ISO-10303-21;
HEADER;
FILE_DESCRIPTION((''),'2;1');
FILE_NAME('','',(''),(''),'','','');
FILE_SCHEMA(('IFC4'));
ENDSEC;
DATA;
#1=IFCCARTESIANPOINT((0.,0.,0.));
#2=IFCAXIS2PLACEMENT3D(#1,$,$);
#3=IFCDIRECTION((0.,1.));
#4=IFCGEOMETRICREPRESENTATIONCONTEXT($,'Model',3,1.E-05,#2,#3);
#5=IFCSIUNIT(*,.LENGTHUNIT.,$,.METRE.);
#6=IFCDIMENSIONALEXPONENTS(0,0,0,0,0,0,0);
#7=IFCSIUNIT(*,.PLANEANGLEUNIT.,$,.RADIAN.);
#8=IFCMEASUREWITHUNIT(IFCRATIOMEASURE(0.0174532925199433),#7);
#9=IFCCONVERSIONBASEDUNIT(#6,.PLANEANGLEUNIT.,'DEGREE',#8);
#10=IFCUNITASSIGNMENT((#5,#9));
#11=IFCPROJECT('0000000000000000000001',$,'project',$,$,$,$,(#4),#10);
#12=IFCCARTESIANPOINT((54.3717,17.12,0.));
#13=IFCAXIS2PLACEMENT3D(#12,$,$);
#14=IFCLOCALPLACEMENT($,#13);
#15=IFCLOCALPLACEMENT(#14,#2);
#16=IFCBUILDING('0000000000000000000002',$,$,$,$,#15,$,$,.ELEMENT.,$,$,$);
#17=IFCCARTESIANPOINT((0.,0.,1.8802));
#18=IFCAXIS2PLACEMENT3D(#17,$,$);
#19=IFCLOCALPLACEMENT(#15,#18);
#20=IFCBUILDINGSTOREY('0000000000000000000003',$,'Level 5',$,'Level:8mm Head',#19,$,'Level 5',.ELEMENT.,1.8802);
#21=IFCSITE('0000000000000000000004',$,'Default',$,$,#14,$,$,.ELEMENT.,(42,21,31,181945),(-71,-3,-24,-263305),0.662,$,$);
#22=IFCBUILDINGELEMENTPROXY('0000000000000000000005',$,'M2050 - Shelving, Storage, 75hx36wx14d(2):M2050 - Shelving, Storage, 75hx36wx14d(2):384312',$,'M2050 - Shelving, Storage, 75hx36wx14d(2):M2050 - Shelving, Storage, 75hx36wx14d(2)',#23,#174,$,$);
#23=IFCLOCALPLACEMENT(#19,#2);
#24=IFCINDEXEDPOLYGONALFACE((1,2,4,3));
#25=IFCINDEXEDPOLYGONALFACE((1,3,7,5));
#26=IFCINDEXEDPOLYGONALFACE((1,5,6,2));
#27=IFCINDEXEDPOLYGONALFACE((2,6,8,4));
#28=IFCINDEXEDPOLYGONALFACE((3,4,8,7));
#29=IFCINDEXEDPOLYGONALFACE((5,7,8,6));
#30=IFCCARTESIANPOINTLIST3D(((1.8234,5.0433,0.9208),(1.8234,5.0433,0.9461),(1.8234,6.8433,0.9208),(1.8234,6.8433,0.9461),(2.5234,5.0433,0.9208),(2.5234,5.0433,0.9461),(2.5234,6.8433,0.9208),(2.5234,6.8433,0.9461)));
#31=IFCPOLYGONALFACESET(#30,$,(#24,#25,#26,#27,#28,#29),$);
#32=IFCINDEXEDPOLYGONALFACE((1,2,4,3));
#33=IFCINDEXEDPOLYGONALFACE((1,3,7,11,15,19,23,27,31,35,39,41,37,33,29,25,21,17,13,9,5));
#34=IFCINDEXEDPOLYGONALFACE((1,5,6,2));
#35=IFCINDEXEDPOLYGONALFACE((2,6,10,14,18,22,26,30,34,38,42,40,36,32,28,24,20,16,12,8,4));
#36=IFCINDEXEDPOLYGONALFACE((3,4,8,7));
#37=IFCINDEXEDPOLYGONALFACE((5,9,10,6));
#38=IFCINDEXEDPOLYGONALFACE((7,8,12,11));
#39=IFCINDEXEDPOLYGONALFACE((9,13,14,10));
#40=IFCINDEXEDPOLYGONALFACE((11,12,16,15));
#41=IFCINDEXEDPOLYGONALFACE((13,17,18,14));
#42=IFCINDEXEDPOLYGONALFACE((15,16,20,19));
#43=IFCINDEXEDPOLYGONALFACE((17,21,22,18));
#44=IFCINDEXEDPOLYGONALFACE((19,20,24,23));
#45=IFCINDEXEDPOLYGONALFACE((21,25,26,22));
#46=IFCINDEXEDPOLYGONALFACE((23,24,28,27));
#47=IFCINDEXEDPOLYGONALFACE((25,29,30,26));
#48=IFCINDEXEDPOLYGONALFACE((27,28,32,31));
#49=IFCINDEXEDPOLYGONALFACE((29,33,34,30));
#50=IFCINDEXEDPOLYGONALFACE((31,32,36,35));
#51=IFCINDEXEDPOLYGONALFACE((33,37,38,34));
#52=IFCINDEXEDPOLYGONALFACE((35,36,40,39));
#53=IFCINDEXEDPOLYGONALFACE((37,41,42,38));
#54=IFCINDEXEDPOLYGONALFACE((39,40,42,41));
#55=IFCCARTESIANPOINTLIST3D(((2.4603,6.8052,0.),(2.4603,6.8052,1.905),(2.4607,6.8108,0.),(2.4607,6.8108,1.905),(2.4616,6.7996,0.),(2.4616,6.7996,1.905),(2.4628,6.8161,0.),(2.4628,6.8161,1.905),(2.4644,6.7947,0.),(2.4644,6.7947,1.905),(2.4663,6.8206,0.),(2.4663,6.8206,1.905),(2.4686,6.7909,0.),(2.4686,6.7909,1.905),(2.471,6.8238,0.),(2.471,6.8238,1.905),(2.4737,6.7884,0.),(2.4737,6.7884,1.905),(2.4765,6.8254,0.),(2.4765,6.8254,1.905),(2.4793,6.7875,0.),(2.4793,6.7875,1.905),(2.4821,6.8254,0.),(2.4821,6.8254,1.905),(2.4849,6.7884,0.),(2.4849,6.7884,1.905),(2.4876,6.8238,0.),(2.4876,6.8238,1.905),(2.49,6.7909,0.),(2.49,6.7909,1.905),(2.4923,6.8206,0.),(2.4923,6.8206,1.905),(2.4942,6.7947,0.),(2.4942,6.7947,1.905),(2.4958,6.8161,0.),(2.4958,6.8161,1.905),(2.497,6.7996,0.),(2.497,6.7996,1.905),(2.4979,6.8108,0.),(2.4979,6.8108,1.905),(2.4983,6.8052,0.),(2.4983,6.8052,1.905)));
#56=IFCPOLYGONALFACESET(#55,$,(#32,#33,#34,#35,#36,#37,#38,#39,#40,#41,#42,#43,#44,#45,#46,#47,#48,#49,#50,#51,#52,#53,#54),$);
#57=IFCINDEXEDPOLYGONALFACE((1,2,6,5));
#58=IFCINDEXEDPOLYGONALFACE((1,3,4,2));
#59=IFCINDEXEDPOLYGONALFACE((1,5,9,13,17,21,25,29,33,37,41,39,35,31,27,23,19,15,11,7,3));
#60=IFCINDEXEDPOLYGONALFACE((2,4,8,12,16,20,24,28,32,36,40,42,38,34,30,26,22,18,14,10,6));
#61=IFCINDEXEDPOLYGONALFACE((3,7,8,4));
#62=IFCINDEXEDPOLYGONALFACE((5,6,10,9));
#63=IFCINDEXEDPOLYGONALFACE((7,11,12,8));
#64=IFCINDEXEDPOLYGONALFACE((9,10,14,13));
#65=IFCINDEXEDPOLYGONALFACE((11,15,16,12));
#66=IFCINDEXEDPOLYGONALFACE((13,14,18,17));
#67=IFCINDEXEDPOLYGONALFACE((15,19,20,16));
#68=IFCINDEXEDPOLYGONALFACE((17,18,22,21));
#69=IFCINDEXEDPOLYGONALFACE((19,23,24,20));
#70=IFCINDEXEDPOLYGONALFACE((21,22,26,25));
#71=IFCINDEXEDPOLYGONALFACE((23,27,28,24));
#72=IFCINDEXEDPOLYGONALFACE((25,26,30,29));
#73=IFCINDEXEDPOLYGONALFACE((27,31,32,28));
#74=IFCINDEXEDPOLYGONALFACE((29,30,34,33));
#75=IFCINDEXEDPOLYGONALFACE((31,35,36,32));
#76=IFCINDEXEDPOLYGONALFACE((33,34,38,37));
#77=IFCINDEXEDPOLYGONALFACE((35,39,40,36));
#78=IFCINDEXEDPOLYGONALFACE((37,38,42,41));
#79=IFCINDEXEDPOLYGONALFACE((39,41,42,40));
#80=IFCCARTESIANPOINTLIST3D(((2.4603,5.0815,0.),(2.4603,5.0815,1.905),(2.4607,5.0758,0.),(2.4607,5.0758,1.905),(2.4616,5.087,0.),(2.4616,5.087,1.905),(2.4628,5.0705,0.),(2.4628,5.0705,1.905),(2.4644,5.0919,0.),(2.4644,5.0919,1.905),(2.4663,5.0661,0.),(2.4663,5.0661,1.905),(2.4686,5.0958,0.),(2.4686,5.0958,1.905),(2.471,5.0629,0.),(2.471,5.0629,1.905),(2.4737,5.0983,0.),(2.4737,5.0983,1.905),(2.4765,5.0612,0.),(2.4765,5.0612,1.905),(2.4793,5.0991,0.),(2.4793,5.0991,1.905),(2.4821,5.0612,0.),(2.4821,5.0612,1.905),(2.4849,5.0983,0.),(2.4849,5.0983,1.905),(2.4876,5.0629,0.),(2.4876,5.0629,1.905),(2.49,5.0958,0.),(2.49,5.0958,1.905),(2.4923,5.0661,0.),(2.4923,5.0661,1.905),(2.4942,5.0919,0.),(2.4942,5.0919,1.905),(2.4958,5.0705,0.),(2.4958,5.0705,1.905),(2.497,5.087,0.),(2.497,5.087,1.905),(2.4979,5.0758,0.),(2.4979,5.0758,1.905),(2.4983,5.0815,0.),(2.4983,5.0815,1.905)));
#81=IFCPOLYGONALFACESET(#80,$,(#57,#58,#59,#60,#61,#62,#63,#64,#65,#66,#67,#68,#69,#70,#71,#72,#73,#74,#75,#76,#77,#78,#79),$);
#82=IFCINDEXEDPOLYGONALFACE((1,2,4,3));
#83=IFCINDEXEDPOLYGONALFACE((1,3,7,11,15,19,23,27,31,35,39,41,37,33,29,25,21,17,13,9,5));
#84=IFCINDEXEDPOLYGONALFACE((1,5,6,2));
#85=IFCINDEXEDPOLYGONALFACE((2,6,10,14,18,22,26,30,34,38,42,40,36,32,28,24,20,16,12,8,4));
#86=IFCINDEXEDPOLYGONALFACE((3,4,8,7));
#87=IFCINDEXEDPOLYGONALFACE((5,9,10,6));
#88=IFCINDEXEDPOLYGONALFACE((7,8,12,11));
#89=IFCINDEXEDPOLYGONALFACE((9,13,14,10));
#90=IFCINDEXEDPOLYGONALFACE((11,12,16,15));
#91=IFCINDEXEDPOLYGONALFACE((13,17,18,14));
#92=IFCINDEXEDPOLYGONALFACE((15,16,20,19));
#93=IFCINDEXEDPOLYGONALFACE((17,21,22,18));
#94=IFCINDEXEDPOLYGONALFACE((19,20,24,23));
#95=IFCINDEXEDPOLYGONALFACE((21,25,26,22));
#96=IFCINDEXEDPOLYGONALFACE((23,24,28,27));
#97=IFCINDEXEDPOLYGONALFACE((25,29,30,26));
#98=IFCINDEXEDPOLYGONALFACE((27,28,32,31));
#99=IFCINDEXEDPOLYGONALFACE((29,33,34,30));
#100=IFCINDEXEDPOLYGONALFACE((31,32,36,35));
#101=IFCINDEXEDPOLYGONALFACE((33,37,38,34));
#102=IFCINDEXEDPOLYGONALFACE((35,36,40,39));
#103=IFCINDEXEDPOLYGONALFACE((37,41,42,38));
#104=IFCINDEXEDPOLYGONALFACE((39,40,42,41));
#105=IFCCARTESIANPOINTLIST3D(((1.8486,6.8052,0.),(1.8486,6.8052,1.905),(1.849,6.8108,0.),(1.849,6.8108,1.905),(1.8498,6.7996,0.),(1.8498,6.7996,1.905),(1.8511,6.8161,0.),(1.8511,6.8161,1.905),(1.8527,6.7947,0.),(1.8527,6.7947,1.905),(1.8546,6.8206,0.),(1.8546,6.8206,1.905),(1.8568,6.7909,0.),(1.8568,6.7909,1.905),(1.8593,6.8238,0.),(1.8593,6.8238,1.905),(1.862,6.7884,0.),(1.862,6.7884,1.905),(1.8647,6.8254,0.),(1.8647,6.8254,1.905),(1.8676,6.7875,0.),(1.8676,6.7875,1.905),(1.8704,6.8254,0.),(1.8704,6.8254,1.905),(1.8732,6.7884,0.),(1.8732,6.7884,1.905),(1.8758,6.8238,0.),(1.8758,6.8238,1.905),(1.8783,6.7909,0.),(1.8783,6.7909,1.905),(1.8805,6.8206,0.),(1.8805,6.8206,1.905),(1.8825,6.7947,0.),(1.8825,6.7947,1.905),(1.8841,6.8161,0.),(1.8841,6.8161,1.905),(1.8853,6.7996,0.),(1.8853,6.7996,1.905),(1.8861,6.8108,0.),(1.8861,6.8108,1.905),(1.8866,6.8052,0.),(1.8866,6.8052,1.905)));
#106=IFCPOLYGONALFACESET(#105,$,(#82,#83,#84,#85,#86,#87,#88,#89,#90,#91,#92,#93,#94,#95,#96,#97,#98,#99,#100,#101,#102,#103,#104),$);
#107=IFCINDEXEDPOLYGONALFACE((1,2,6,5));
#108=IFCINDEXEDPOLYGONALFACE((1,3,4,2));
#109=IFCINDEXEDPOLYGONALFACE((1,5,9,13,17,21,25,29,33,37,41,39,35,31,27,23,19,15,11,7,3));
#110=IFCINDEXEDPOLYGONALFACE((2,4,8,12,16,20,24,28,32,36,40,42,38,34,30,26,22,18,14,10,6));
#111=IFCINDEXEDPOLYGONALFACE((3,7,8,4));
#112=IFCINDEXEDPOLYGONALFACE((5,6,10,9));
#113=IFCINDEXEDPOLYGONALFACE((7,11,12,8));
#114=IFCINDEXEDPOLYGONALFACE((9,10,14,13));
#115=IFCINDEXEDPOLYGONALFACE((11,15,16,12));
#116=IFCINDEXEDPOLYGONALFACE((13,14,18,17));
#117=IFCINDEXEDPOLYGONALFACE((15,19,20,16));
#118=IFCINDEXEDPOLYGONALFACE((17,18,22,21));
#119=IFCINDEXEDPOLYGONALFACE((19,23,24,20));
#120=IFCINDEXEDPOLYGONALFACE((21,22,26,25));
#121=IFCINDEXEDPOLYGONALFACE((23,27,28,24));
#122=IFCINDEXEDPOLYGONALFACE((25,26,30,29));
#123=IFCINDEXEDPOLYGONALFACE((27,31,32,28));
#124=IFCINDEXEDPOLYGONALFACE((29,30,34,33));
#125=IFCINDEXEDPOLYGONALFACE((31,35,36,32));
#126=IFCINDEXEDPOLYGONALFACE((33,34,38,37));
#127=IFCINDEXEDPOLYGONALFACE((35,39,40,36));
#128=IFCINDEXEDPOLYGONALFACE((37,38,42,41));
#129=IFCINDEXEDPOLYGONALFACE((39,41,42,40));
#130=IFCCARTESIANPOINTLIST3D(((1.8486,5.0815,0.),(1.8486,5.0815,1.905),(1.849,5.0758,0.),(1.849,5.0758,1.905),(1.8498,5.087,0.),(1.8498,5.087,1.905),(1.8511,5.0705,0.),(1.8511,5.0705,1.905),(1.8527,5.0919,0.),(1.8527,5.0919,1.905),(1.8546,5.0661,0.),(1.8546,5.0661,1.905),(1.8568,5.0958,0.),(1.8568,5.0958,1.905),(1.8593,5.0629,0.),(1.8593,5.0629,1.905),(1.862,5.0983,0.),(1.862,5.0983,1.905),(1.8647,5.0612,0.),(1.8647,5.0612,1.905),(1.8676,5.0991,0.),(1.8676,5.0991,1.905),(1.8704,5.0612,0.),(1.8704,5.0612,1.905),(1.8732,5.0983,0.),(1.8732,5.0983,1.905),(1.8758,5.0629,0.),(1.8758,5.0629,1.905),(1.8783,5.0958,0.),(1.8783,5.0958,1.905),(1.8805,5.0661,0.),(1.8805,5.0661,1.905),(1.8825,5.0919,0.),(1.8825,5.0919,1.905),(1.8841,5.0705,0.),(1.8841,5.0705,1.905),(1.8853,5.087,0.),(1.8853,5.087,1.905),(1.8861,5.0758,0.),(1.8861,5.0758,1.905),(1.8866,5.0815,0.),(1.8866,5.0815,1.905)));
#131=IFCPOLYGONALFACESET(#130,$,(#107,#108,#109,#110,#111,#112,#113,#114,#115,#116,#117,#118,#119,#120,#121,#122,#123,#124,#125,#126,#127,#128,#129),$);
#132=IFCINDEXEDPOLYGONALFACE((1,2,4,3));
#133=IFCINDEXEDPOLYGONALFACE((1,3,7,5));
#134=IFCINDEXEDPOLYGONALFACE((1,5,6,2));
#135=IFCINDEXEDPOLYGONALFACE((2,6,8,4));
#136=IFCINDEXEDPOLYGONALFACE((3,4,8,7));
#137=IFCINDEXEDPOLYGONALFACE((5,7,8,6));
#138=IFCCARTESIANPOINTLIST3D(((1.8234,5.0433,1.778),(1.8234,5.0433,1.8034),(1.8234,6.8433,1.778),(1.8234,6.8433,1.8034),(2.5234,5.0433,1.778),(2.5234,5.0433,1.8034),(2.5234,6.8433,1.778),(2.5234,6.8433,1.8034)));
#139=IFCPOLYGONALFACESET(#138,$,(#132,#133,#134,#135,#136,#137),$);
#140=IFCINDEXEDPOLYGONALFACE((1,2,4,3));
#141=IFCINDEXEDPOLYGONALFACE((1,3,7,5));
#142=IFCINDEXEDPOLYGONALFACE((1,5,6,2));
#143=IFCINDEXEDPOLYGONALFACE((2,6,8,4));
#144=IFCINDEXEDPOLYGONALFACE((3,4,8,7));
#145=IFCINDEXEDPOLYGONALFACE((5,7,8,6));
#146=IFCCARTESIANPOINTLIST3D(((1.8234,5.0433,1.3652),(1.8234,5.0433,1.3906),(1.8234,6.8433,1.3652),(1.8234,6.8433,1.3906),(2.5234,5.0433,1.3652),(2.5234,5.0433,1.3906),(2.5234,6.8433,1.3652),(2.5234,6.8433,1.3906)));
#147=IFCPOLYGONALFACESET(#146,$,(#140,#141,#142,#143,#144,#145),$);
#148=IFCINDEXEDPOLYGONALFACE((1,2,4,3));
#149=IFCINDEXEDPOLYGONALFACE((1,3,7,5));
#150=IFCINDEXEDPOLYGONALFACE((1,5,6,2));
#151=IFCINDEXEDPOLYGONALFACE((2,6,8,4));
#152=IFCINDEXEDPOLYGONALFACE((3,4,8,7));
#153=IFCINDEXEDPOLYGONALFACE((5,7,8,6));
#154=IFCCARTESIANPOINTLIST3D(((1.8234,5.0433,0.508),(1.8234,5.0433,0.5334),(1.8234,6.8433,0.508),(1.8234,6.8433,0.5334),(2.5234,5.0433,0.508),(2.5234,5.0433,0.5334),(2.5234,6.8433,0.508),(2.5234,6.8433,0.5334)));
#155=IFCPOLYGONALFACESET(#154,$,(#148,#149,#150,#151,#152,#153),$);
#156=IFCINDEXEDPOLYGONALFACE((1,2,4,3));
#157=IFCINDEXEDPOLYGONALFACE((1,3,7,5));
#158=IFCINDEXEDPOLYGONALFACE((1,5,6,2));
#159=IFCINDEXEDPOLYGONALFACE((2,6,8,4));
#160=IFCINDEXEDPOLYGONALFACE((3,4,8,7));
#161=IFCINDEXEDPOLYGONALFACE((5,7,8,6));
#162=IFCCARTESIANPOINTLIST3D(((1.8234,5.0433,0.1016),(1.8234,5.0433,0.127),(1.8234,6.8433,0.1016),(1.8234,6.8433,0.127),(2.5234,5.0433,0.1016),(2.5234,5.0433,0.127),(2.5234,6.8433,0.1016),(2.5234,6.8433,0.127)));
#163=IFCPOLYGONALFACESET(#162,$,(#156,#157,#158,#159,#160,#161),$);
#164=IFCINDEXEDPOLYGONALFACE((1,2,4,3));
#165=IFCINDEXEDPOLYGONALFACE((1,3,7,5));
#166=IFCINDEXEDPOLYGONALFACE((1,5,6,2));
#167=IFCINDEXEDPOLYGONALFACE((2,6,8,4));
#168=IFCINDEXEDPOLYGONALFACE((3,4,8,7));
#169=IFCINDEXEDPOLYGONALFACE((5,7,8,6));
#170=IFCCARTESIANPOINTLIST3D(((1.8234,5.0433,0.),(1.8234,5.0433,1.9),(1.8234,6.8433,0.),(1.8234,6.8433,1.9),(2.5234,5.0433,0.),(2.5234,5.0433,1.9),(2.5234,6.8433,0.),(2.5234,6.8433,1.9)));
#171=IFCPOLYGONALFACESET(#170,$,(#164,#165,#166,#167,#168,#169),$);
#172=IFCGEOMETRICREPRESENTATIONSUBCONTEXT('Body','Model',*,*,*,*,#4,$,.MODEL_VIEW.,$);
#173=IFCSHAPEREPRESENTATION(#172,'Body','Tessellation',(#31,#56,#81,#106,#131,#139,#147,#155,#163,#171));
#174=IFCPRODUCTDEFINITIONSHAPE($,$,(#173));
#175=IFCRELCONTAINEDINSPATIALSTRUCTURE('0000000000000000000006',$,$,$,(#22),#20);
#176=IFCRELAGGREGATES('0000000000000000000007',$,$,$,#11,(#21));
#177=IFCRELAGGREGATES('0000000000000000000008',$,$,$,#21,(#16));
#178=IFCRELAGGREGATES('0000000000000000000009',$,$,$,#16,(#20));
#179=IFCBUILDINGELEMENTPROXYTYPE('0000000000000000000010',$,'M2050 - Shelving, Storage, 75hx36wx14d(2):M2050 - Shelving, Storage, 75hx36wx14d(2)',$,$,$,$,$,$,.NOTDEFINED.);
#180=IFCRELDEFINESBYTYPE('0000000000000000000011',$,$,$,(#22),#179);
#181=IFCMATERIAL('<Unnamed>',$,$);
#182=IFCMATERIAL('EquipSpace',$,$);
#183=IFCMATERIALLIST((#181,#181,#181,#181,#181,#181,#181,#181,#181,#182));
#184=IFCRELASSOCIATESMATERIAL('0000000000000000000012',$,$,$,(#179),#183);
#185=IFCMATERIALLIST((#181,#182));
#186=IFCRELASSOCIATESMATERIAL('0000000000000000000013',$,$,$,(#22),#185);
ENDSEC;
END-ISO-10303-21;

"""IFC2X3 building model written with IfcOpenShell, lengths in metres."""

from ifc_helpers import new_model, entity, si_unit, converted_unit, direction, frame, frame_2d, origin, origin_2d_with_axis, place, context, subcontext, project, spatial, rectangle, circle, extrude, source, transform, mapped, material, material_list, type_object, type_shapes, element, save


model = new_model("IFC2X3")

# Units and contexts
model_context = context("Model", 3, precision=1e-05, world=origin(), true_north=direction((0.0, 1.0)))
body_context = subcontext(model_context, "Body", "Model", "MODEL_VIEW")
ifc_project = project(units=[si_unit("LENGTHUNIT", "METRE"), converted_unit("PLANEANGLEUNIT", "DEGREE", entity("IfcRatioMeasure", 0.0174532925199433), si_unit("PLANEANGLEUNIT", "RADIAN"), dimensions=[0, 0, 0, 0, 0, 0, 0])], contexts=[model_context])

# Site, building, storey
site_placement = place(None, frame((54.3717, 17.12, 0.0)))
site = spatial("IfcSite", under=ifc_project, at=site_placement, Name="Default", CompositionType="ELEMENT", RefLatitude=(42, 21, 31, 181945), RefLongitude=(-71, -3, -24, -263305), RefElevation=0.662)
building_placement = place(site_placement, origin())
building = spatial("IfcBuilding", under=site, at=building_placement, CompositionType="ELEMENT")
storey_placement = place(building_placement, frame((0.0, 0.0, 1.8802)))
storey = spatial("IfcBuildingStorey", under=building, at=storey_placement, Name="Level 5", ObjectType="Level:8mm Head", LongName="Level 5", CompositionType="ELEMENT", Elevation=1.8802)

# Building element proxy
ifc_material_1 = material(Name="<Unnamed>")
ifc_material_2 = material(Name="EquipSpace")
ifc_material_list_1 = material_list([ifc_material_1, ifc_material_1, ifc_material_1, ifc_material_1, ifc_material_1, ifc_material_1, ifc_material_1, ifc_material_1, ifc_material_1, ifc_material_2])
building_element_proxy_type = type_object("IfcBuildingElementProxyType", Name="M2050 - Shelving, Storage, 75hx36wx14d(2):M2050 - Shelving, Storage, 75hx36wx14d(2)", PredefinedType="NOTDEFINED", material=ifc_material_list_1)
shared_shape = source(origin(), body_context, "Body", "SweptSolid", [
    extrude(rectangle(XDim=1.8, YDim=0.7, at=origin_2d_with_axis()), frame((0.0, 0.0, 0.9207), z_axis=(0.0, 0.0, 1.0), x_axis=(-1.0, 0.0, 0.0)), (0.0, 0.0, 1.0), 0.0254),
    extrude(circle(Radius=0.0191, at=origin_2d_with_axis()), frame((0.8633, -0.3059, 0.0), z_axis=(0.0, 0.0, 1.0), x_axis=(-1.0, 0.0, 0.0)), (0.0, 0.0, 1.0), 1.905),
    extrude(circle(Radius=0.0191, at=origin_2d_with_axis()), frame((-0.8633, -0.3059, 0.0)), (0.0, 0.0, 1.0), 1.905),
    extrude(circle(Radius=0.0191, at=origin_2d_with_axis()), frame((0.8633, 0.3059, 0.0), z_axis=(0.0, 0.0, 1.0), x_axis=(-1.0, 0.0, 0.0)), (0.0, 0.0, 1.0), 1.905),
    extrude(circle(Radius=0.0191, at=origin_2d_with_axis()), frame((-0.8633, 0.3059, 0.0)), (0.0, 0.0, 1.0), 1.905),
    extrude(rectangle(XDim=1.8, YDim=0.7, at=origin_2d_with_axis()), frame((0.0, 0.0, 1.778), z_axis=(0.0, 0.0, 1.0), x_axis=(-1.0, 0.0, 0.0)), (0.0, 0.0, 1.0), 0.0254),
    extrude(rectangle(XDim=1.8, YDim=0.7, at=origin_2d_with_axis()), frame((0.0, 0.0, 1.3653), z_axis=(0.0, 0.0, 1.0), x_axis=(-1.0, 0.0, 0.0)), (0.0, 0.0, 1.0), 0.0254),
    extrude(rectangle(XDim=1.8, YDim=0.7, at=origin_2d_with_axis()), frame((0.0, 0.0, 0.508), z_axis=(0.0, 0.0, 1.0), x_axis=(-1.0, 0.0, 0.0)), (0.0, 0.0, 1.0), 0.0254),
    extrude(rectangle(XDim=1.8, YDim=0.7, at=origin_2d_with_axis()), frame((0.0, 0.0, 0.1016), z_axis=(0.0, 0.0, 1.0), x_axis=(-1.0, 0.0, 0.0)), (0.0, 0.0, 1.0), 0.0254),
    extrude(rectangle(XDim=0.7, YDim=1.8, at=frame_2d((0.0, 0.18), x_axis=(1.0, 0.0))), frame((-0.18, 0.0, 0.0), z_axis=(0.0, 0.0, 1.0), x_axis=(0.0, -1.0, 0.0)), (0.0, 0.0, 1.0), 1.9),
])
type_shapes(building_element_proxy_type, [shared_shape])
ifc_material_list_2 = material_list([ifc_material_1, ifc_material_2])
proxy_1_placement = place(storey_placement, frame((2.1734, 5.9433, 0.0), z_axis=(0.0, 0.0, 1.0), x_axis=(0.0, 1.0, 0.0)))
element("IfcBuildingElementProxy", 1, at=proxy_1_placement, inside=storey, type_object=building_element_proxy_type, material=ifc_material_list_2, Name="M2050 - Shelving, Storage, 75hx36wx14d(2):M2050 - Shelving, Storage, 75hx36wx14d(2):384312", ObjectType="M2050 - Shelving, Storage, 75hx36wx14d(2):M2050 - Shelving, Storage, 75hx36wx14d(2)", context=body_context, shape_type="MappedRepresentation", body=[
    mapped(shared_shape, transform((0.0, 0.0, 0.0), scale=1.0)),
])

save(model, "model.ifc")
